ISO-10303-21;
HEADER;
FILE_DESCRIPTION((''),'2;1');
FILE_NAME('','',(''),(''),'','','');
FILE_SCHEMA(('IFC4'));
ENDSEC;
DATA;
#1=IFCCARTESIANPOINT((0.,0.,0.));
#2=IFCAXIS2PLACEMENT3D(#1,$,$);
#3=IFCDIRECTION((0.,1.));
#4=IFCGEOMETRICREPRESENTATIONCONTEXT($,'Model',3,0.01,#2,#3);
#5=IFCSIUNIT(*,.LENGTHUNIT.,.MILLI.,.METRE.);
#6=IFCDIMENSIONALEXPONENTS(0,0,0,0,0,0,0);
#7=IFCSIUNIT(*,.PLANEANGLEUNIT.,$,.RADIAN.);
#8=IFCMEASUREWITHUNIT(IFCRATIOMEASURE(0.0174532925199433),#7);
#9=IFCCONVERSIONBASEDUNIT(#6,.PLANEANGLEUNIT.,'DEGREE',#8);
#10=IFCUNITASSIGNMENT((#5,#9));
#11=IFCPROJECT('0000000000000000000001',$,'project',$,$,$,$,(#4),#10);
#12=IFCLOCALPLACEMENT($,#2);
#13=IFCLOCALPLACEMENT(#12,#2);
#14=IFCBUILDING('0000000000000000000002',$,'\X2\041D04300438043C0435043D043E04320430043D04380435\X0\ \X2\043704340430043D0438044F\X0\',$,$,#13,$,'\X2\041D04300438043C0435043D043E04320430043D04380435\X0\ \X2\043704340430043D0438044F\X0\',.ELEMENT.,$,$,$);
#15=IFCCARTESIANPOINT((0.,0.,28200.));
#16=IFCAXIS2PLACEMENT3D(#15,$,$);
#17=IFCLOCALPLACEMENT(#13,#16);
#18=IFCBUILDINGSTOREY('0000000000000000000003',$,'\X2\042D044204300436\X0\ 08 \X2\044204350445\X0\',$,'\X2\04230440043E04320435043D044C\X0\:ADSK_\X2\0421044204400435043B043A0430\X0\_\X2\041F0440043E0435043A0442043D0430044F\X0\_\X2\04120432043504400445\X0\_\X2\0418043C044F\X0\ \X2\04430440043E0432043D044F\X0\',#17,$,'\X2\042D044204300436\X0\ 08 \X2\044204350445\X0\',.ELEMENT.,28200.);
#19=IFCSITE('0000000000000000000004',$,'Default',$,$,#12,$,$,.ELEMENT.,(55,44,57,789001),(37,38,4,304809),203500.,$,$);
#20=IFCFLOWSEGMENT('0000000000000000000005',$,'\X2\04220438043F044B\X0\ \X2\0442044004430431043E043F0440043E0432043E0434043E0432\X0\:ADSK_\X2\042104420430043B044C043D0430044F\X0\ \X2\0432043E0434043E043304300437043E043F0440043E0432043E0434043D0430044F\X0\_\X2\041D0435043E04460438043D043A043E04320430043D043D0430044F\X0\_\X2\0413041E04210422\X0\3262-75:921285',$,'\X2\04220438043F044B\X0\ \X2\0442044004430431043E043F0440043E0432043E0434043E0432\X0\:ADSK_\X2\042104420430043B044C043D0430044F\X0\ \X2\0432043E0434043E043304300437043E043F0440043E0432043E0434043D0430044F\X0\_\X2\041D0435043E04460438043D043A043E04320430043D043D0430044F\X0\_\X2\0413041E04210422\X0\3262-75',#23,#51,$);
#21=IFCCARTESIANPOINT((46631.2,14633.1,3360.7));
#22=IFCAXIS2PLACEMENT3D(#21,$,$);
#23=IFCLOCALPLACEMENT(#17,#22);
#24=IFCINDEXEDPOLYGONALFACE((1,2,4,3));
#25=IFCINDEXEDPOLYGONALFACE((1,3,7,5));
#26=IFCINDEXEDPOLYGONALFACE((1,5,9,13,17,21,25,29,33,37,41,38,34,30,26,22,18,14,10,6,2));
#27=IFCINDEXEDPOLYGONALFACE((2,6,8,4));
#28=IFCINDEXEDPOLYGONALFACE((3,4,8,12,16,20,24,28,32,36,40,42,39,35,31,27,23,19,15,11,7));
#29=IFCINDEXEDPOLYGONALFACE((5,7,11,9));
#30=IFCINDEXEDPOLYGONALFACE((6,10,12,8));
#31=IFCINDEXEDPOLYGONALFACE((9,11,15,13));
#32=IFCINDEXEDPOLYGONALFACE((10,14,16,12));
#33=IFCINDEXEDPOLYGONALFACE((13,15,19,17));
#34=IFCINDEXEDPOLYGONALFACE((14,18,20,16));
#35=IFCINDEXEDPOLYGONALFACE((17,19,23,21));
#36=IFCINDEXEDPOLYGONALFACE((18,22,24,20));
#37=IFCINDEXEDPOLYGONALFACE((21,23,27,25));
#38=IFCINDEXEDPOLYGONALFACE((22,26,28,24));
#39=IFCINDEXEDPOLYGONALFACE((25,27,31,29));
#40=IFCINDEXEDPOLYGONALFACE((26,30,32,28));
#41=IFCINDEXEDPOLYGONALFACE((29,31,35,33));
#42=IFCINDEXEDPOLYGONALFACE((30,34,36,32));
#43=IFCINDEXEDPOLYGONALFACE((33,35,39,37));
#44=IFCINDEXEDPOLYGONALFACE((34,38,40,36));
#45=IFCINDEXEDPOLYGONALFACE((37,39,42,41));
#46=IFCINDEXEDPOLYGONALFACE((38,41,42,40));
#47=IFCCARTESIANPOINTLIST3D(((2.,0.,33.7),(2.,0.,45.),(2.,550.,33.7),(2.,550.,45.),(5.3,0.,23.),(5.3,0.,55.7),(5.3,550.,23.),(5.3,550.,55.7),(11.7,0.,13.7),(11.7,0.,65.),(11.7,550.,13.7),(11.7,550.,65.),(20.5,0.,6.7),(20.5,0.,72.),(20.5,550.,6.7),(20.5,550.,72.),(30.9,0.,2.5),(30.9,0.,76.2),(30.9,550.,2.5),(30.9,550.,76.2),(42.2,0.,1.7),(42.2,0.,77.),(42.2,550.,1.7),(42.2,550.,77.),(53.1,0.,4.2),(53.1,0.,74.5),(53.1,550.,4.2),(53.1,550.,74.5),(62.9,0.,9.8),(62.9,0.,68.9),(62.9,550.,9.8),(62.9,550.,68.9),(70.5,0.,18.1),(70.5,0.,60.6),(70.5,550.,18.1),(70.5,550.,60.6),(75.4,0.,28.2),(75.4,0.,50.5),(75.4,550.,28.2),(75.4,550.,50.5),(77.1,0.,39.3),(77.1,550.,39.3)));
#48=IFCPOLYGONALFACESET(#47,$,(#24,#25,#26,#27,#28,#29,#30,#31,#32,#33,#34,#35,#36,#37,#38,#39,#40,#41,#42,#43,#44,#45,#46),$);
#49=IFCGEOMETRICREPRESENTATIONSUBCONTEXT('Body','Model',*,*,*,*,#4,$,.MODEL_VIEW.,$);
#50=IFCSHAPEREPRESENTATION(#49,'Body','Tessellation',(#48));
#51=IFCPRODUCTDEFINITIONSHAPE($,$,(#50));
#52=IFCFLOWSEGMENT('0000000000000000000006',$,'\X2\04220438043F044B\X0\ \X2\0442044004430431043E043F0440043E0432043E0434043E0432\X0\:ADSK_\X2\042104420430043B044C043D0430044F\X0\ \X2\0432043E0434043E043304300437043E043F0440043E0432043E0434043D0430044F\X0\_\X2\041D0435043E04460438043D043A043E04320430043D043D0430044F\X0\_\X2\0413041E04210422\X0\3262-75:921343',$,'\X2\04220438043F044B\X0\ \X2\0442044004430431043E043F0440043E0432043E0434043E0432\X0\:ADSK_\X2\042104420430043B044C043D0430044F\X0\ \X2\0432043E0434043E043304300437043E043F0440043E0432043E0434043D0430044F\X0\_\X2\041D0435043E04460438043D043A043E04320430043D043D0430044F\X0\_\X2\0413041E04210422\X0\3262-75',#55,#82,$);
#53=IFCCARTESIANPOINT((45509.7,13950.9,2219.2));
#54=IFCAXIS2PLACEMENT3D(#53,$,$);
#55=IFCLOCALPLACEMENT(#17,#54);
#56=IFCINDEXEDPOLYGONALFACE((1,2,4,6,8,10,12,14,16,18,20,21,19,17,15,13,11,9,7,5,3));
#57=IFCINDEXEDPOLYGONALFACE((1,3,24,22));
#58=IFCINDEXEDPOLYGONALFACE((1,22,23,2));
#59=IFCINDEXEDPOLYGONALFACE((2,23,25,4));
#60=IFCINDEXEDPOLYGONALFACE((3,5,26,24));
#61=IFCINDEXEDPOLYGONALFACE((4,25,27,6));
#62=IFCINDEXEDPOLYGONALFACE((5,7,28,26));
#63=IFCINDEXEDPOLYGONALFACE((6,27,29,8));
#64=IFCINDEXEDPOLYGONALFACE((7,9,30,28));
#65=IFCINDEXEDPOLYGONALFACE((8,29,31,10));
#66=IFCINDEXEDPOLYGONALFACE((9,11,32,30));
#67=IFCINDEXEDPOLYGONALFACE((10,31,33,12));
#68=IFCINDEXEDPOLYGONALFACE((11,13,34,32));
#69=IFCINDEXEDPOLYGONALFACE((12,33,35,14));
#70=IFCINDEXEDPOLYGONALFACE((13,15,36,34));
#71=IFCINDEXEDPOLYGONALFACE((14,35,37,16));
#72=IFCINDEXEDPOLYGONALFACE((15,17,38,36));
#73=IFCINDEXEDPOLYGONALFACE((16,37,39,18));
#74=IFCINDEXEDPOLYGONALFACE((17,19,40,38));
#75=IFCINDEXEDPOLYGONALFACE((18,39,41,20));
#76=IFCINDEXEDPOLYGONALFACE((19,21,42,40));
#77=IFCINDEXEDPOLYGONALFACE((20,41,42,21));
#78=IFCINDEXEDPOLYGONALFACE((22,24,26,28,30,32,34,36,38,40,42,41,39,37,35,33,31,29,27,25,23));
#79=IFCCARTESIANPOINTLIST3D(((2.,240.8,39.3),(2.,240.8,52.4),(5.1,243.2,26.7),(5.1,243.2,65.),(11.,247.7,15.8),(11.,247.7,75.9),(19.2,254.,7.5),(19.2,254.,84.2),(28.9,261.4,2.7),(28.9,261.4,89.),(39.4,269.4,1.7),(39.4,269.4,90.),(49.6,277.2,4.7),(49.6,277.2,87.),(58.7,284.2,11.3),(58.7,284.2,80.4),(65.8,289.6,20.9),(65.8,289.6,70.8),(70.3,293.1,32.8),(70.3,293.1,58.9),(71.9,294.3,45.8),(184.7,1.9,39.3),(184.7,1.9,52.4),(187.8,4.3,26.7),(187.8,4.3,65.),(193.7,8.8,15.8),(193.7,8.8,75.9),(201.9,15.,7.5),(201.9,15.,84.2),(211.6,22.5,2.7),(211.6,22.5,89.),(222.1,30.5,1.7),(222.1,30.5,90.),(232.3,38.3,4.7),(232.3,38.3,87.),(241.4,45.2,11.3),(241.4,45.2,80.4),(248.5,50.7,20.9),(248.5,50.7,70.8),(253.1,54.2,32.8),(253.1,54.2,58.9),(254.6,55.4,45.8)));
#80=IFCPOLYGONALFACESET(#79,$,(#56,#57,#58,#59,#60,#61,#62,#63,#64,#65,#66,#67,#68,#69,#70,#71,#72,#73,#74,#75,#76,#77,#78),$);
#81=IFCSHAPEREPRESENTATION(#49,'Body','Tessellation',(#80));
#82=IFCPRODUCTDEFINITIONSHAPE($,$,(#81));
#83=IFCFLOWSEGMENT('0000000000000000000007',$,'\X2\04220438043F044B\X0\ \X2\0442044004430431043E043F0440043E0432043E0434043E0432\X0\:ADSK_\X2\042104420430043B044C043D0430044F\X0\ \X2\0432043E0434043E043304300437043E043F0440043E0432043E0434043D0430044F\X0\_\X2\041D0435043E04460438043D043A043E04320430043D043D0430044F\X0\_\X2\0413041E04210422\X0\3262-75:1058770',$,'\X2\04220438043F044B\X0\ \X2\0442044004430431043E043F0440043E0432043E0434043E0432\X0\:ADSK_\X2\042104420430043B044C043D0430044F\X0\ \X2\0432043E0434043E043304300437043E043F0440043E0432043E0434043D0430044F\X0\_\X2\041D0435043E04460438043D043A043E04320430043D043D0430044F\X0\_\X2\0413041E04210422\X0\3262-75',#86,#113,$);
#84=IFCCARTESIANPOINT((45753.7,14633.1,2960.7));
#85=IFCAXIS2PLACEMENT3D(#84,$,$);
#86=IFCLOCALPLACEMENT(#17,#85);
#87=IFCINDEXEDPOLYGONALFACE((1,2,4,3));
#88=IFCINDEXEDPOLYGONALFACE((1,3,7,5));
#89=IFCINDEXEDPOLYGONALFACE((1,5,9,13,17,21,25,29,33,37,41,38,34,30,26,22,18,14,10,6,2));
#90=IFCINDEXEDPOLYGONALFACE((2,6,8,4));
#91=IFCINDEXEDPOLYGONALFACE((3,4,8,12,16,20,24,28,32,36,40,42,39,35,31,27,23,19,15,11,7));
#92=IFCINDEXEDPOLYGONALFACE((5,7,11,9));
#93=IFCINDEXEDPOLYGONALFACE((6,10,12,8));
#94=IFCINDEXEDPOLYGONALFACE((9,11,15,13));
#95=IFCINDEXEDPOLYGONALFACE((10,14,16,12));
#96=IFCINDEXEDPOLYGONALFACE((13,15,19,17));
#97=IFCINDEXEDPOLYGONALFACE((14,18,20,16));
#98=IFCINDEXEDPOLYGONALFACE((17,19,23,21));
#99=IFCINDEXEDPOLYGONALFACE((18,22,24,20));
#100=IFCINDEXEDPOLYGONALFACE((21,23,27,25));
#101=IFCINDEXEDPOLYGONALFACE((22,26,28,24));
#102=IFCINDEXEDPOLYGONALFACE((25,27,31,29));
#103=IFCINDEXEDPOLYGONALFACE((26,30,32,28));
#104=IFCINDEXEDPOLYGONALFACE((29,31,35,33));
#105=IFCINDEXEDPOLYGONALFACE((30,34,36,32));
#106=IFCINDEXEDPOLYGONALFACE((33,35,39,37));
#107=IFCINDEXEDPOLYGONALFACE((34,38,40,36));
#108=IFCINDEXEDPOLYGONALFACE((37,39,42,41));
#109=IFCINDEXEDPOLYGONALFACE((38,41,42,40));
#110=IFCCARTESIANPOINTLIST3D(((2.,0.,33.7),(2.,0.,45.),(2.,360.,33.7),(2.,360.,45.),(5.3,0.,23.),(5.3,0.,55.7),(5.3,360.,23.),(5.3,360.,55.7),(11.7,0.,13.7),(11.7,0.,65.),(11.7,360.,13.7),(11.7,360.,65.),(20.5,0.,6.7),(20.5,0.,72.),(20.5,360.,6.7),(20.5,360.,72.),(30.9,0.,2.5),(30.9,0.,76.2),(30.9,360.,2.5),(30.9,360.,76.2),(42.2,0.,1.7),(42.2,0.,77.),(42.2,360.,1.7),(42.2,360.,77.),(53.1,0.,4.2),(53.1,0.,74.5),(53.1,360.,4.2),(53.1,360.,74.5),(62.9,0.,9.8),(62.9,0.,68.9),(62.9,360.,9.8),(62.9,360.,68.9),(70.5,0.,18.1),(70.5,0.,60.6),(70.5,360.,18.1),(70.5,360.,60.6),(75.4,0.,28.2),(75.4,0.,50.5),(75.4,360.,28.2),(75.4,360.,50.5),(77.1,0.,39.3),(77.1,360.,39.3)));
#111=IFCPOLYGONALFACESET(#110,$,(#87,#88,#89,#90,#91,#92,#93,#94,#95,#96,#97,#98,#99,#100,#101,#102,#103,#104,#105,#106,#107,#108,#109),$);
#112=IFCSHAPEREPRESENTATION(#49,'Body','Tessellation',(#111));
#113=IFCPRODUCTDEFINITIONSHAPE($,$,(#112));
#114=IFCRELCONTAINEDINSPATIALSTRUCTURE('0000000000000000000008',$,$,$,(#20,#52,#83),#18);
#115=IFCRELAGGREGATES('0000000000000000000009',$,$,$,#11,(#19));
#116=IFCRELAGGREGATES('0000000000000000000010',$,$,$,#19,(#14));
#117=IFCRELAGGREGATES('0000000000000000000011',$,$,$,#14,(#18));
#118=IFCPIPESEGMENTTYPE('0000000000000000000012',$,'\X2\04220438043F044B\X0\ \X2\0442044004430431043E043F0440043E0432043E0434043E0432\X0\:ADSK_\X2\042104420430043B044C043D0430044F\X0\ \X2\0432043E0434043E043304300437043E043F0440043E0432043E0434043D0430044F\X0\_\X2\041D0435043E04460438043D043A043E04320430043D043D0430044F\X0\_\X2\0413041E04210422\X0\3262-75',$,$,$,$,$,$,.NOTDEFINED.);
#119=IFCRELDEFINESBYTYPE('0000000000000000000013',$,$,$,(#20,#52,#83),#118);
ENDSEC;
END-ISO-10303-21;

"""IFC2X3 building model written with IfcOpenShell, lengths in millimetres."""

from ifc_helpers import new_model, entity, si_unit, converted_unit, direction, frame, origin, origin_2d_with_axis, place, context, subcontext, project, spatial, circle, extrude, type_object, element, save


model = new_model("IFC2X3")

# Units and contexts
model_context = context("Model", 3, precision=0.01, world=origin(), true_north=direction((0.0, 1.0)))
body_context = subcontext(model_context, "Body", "Model", "MODEL_VIEW")
ifc_project = project(units=[si_unit("LENGTHUNIT", "METRE", prefix="MILLI"), converted_unit("PLANEANGLEUNIT", "DEGREE", entity("IfcRatioMeasure", 0.0174532925199433), si_unit("PLANEANGLEUNIT", "RADIAN"), dimensions=[0, 0, 0, 0, 0, 0, 0])], contexts=[model_context])

# Site, building, storey
site_placement = place(None, origin())
site = spatial("IfcSite", under=ifc_project, at=site_placement, Name="Default", CompositionType="ELEMENT", RefLatitude=(55, 44, 57, 789001), RefLongitude=(37, 38, 4, 304809), RefElevation=203500.0)
building_placement = place(site_placement, origin())
building = spatial("IfcBuilding", under=site, at=building_placement, Name="Наименование здания", LongName="Наименование здания", CompositionType="ELEMENT")
storey_placement = place(building_placement, frame((0.0, 0.0, 28200.0)))
storey = spatial("IfcBuildingStorey", under=building, at=storey_placement, Name="Этаж 08 тех", ObjectType="Уровень:ADSK_Стрелка_Проектная_Вверх_Имя уровня", LongName="Этаж 08 тех", CompositionType="ELEMENT", Elevation=28200.0)

# Flow segments
pipe_segment_type = type_object("IfcPipeSegmentType", Name="Типы трубопроводов:ADSK_Стальная водогазопроводная_Неоцинкованная_ГОСТ3262-75", PredefinedType="NOTDEFINED")
flow_segment_1_placement = place(storey_placement, frame((46631.2, 14633.1, 3360.7)))
element("IfcFlowSegment", 1, at=flow_segment_1_placement, inside=storey, type_object=pipe_segment_type, Name="Типы трубопроводов:ADSK_Стальная водогазопроводная_Неоцинкованная_ГОСТ3262-75:921285", ObjectType="Типы трубопроводов:ADSK_Стальная водогазопроводная_Неоцинкованная_ГОСТ3262-75", context=body_context, shape_type="SweptSolid", body=[
    extrude(circle(Radius=37.8, at=origin_2d_with_axis()), frame((39.4, 0.0, 39.4), z_axis=(0.0, 1.0, 0.0), x_axis=(1.0, 0.0, 0.0)), (0.0, 0.0, 1.0), 550.0),
])
flow_segment_2_placement = place(storey_placement, frame((45509.7, 13950.9, 2219.2)))
element("IfcFlowSegment", 2, at=flow_segment_2_placement, inside=storey, type_object=pipe_segment_type, Name="Типы трубопроводов:ADSK_Стальная водогазопроводная_Неоцинкованная_ГОСТ3262-75:921343", ObjectType="Типы трубопроводов:ADSK_Стальная водогазопроводная_Неоцинкованная_ГОСТ3262-75", context=body_context, shape_type="SweptSolid", body=[
    extrude(circle(Radius=44.2, at=origin_2d_with_axis()), frame((36.7, 267.4, 45.9), z_axis=(0.607471, -0.794342, 0.0), x_axis=(0.794342, 0.607471, 0.0)), (0.0, 0.0, 1.0), 300.8),
])
flow_segment_3_placement = place(storey_placement, frame((45753.7, 14633.1, 2960.7)))
element("IfcFlowSegment", 3, at=flow_segment_3_placement, inside=storey, type_object=pipe_segment_type, Name="Типы трубопроводов:ADSK_Стальная водогазопроводная_Неоцинкованная_ГОСТ3262-75:1058770", ObjectType="Типы трубопроводов:ADSK_Стальная водогазопроводная_Неоцинкованная_ГОСТ3262-75", context=body_context, shape_type="SweptSolid", body=[
    extrude(circle(Radius=37.8, at=origin_2d_with_axis()), frame((39.4, 0.0, 39.4), z_axis=(0.0, 1.0, 0.0), x_axis=(1.0, 0.0, 0.0)), (0.0, 0.0, 1.0), 360.0),
])

save(model, "model.ifc")
